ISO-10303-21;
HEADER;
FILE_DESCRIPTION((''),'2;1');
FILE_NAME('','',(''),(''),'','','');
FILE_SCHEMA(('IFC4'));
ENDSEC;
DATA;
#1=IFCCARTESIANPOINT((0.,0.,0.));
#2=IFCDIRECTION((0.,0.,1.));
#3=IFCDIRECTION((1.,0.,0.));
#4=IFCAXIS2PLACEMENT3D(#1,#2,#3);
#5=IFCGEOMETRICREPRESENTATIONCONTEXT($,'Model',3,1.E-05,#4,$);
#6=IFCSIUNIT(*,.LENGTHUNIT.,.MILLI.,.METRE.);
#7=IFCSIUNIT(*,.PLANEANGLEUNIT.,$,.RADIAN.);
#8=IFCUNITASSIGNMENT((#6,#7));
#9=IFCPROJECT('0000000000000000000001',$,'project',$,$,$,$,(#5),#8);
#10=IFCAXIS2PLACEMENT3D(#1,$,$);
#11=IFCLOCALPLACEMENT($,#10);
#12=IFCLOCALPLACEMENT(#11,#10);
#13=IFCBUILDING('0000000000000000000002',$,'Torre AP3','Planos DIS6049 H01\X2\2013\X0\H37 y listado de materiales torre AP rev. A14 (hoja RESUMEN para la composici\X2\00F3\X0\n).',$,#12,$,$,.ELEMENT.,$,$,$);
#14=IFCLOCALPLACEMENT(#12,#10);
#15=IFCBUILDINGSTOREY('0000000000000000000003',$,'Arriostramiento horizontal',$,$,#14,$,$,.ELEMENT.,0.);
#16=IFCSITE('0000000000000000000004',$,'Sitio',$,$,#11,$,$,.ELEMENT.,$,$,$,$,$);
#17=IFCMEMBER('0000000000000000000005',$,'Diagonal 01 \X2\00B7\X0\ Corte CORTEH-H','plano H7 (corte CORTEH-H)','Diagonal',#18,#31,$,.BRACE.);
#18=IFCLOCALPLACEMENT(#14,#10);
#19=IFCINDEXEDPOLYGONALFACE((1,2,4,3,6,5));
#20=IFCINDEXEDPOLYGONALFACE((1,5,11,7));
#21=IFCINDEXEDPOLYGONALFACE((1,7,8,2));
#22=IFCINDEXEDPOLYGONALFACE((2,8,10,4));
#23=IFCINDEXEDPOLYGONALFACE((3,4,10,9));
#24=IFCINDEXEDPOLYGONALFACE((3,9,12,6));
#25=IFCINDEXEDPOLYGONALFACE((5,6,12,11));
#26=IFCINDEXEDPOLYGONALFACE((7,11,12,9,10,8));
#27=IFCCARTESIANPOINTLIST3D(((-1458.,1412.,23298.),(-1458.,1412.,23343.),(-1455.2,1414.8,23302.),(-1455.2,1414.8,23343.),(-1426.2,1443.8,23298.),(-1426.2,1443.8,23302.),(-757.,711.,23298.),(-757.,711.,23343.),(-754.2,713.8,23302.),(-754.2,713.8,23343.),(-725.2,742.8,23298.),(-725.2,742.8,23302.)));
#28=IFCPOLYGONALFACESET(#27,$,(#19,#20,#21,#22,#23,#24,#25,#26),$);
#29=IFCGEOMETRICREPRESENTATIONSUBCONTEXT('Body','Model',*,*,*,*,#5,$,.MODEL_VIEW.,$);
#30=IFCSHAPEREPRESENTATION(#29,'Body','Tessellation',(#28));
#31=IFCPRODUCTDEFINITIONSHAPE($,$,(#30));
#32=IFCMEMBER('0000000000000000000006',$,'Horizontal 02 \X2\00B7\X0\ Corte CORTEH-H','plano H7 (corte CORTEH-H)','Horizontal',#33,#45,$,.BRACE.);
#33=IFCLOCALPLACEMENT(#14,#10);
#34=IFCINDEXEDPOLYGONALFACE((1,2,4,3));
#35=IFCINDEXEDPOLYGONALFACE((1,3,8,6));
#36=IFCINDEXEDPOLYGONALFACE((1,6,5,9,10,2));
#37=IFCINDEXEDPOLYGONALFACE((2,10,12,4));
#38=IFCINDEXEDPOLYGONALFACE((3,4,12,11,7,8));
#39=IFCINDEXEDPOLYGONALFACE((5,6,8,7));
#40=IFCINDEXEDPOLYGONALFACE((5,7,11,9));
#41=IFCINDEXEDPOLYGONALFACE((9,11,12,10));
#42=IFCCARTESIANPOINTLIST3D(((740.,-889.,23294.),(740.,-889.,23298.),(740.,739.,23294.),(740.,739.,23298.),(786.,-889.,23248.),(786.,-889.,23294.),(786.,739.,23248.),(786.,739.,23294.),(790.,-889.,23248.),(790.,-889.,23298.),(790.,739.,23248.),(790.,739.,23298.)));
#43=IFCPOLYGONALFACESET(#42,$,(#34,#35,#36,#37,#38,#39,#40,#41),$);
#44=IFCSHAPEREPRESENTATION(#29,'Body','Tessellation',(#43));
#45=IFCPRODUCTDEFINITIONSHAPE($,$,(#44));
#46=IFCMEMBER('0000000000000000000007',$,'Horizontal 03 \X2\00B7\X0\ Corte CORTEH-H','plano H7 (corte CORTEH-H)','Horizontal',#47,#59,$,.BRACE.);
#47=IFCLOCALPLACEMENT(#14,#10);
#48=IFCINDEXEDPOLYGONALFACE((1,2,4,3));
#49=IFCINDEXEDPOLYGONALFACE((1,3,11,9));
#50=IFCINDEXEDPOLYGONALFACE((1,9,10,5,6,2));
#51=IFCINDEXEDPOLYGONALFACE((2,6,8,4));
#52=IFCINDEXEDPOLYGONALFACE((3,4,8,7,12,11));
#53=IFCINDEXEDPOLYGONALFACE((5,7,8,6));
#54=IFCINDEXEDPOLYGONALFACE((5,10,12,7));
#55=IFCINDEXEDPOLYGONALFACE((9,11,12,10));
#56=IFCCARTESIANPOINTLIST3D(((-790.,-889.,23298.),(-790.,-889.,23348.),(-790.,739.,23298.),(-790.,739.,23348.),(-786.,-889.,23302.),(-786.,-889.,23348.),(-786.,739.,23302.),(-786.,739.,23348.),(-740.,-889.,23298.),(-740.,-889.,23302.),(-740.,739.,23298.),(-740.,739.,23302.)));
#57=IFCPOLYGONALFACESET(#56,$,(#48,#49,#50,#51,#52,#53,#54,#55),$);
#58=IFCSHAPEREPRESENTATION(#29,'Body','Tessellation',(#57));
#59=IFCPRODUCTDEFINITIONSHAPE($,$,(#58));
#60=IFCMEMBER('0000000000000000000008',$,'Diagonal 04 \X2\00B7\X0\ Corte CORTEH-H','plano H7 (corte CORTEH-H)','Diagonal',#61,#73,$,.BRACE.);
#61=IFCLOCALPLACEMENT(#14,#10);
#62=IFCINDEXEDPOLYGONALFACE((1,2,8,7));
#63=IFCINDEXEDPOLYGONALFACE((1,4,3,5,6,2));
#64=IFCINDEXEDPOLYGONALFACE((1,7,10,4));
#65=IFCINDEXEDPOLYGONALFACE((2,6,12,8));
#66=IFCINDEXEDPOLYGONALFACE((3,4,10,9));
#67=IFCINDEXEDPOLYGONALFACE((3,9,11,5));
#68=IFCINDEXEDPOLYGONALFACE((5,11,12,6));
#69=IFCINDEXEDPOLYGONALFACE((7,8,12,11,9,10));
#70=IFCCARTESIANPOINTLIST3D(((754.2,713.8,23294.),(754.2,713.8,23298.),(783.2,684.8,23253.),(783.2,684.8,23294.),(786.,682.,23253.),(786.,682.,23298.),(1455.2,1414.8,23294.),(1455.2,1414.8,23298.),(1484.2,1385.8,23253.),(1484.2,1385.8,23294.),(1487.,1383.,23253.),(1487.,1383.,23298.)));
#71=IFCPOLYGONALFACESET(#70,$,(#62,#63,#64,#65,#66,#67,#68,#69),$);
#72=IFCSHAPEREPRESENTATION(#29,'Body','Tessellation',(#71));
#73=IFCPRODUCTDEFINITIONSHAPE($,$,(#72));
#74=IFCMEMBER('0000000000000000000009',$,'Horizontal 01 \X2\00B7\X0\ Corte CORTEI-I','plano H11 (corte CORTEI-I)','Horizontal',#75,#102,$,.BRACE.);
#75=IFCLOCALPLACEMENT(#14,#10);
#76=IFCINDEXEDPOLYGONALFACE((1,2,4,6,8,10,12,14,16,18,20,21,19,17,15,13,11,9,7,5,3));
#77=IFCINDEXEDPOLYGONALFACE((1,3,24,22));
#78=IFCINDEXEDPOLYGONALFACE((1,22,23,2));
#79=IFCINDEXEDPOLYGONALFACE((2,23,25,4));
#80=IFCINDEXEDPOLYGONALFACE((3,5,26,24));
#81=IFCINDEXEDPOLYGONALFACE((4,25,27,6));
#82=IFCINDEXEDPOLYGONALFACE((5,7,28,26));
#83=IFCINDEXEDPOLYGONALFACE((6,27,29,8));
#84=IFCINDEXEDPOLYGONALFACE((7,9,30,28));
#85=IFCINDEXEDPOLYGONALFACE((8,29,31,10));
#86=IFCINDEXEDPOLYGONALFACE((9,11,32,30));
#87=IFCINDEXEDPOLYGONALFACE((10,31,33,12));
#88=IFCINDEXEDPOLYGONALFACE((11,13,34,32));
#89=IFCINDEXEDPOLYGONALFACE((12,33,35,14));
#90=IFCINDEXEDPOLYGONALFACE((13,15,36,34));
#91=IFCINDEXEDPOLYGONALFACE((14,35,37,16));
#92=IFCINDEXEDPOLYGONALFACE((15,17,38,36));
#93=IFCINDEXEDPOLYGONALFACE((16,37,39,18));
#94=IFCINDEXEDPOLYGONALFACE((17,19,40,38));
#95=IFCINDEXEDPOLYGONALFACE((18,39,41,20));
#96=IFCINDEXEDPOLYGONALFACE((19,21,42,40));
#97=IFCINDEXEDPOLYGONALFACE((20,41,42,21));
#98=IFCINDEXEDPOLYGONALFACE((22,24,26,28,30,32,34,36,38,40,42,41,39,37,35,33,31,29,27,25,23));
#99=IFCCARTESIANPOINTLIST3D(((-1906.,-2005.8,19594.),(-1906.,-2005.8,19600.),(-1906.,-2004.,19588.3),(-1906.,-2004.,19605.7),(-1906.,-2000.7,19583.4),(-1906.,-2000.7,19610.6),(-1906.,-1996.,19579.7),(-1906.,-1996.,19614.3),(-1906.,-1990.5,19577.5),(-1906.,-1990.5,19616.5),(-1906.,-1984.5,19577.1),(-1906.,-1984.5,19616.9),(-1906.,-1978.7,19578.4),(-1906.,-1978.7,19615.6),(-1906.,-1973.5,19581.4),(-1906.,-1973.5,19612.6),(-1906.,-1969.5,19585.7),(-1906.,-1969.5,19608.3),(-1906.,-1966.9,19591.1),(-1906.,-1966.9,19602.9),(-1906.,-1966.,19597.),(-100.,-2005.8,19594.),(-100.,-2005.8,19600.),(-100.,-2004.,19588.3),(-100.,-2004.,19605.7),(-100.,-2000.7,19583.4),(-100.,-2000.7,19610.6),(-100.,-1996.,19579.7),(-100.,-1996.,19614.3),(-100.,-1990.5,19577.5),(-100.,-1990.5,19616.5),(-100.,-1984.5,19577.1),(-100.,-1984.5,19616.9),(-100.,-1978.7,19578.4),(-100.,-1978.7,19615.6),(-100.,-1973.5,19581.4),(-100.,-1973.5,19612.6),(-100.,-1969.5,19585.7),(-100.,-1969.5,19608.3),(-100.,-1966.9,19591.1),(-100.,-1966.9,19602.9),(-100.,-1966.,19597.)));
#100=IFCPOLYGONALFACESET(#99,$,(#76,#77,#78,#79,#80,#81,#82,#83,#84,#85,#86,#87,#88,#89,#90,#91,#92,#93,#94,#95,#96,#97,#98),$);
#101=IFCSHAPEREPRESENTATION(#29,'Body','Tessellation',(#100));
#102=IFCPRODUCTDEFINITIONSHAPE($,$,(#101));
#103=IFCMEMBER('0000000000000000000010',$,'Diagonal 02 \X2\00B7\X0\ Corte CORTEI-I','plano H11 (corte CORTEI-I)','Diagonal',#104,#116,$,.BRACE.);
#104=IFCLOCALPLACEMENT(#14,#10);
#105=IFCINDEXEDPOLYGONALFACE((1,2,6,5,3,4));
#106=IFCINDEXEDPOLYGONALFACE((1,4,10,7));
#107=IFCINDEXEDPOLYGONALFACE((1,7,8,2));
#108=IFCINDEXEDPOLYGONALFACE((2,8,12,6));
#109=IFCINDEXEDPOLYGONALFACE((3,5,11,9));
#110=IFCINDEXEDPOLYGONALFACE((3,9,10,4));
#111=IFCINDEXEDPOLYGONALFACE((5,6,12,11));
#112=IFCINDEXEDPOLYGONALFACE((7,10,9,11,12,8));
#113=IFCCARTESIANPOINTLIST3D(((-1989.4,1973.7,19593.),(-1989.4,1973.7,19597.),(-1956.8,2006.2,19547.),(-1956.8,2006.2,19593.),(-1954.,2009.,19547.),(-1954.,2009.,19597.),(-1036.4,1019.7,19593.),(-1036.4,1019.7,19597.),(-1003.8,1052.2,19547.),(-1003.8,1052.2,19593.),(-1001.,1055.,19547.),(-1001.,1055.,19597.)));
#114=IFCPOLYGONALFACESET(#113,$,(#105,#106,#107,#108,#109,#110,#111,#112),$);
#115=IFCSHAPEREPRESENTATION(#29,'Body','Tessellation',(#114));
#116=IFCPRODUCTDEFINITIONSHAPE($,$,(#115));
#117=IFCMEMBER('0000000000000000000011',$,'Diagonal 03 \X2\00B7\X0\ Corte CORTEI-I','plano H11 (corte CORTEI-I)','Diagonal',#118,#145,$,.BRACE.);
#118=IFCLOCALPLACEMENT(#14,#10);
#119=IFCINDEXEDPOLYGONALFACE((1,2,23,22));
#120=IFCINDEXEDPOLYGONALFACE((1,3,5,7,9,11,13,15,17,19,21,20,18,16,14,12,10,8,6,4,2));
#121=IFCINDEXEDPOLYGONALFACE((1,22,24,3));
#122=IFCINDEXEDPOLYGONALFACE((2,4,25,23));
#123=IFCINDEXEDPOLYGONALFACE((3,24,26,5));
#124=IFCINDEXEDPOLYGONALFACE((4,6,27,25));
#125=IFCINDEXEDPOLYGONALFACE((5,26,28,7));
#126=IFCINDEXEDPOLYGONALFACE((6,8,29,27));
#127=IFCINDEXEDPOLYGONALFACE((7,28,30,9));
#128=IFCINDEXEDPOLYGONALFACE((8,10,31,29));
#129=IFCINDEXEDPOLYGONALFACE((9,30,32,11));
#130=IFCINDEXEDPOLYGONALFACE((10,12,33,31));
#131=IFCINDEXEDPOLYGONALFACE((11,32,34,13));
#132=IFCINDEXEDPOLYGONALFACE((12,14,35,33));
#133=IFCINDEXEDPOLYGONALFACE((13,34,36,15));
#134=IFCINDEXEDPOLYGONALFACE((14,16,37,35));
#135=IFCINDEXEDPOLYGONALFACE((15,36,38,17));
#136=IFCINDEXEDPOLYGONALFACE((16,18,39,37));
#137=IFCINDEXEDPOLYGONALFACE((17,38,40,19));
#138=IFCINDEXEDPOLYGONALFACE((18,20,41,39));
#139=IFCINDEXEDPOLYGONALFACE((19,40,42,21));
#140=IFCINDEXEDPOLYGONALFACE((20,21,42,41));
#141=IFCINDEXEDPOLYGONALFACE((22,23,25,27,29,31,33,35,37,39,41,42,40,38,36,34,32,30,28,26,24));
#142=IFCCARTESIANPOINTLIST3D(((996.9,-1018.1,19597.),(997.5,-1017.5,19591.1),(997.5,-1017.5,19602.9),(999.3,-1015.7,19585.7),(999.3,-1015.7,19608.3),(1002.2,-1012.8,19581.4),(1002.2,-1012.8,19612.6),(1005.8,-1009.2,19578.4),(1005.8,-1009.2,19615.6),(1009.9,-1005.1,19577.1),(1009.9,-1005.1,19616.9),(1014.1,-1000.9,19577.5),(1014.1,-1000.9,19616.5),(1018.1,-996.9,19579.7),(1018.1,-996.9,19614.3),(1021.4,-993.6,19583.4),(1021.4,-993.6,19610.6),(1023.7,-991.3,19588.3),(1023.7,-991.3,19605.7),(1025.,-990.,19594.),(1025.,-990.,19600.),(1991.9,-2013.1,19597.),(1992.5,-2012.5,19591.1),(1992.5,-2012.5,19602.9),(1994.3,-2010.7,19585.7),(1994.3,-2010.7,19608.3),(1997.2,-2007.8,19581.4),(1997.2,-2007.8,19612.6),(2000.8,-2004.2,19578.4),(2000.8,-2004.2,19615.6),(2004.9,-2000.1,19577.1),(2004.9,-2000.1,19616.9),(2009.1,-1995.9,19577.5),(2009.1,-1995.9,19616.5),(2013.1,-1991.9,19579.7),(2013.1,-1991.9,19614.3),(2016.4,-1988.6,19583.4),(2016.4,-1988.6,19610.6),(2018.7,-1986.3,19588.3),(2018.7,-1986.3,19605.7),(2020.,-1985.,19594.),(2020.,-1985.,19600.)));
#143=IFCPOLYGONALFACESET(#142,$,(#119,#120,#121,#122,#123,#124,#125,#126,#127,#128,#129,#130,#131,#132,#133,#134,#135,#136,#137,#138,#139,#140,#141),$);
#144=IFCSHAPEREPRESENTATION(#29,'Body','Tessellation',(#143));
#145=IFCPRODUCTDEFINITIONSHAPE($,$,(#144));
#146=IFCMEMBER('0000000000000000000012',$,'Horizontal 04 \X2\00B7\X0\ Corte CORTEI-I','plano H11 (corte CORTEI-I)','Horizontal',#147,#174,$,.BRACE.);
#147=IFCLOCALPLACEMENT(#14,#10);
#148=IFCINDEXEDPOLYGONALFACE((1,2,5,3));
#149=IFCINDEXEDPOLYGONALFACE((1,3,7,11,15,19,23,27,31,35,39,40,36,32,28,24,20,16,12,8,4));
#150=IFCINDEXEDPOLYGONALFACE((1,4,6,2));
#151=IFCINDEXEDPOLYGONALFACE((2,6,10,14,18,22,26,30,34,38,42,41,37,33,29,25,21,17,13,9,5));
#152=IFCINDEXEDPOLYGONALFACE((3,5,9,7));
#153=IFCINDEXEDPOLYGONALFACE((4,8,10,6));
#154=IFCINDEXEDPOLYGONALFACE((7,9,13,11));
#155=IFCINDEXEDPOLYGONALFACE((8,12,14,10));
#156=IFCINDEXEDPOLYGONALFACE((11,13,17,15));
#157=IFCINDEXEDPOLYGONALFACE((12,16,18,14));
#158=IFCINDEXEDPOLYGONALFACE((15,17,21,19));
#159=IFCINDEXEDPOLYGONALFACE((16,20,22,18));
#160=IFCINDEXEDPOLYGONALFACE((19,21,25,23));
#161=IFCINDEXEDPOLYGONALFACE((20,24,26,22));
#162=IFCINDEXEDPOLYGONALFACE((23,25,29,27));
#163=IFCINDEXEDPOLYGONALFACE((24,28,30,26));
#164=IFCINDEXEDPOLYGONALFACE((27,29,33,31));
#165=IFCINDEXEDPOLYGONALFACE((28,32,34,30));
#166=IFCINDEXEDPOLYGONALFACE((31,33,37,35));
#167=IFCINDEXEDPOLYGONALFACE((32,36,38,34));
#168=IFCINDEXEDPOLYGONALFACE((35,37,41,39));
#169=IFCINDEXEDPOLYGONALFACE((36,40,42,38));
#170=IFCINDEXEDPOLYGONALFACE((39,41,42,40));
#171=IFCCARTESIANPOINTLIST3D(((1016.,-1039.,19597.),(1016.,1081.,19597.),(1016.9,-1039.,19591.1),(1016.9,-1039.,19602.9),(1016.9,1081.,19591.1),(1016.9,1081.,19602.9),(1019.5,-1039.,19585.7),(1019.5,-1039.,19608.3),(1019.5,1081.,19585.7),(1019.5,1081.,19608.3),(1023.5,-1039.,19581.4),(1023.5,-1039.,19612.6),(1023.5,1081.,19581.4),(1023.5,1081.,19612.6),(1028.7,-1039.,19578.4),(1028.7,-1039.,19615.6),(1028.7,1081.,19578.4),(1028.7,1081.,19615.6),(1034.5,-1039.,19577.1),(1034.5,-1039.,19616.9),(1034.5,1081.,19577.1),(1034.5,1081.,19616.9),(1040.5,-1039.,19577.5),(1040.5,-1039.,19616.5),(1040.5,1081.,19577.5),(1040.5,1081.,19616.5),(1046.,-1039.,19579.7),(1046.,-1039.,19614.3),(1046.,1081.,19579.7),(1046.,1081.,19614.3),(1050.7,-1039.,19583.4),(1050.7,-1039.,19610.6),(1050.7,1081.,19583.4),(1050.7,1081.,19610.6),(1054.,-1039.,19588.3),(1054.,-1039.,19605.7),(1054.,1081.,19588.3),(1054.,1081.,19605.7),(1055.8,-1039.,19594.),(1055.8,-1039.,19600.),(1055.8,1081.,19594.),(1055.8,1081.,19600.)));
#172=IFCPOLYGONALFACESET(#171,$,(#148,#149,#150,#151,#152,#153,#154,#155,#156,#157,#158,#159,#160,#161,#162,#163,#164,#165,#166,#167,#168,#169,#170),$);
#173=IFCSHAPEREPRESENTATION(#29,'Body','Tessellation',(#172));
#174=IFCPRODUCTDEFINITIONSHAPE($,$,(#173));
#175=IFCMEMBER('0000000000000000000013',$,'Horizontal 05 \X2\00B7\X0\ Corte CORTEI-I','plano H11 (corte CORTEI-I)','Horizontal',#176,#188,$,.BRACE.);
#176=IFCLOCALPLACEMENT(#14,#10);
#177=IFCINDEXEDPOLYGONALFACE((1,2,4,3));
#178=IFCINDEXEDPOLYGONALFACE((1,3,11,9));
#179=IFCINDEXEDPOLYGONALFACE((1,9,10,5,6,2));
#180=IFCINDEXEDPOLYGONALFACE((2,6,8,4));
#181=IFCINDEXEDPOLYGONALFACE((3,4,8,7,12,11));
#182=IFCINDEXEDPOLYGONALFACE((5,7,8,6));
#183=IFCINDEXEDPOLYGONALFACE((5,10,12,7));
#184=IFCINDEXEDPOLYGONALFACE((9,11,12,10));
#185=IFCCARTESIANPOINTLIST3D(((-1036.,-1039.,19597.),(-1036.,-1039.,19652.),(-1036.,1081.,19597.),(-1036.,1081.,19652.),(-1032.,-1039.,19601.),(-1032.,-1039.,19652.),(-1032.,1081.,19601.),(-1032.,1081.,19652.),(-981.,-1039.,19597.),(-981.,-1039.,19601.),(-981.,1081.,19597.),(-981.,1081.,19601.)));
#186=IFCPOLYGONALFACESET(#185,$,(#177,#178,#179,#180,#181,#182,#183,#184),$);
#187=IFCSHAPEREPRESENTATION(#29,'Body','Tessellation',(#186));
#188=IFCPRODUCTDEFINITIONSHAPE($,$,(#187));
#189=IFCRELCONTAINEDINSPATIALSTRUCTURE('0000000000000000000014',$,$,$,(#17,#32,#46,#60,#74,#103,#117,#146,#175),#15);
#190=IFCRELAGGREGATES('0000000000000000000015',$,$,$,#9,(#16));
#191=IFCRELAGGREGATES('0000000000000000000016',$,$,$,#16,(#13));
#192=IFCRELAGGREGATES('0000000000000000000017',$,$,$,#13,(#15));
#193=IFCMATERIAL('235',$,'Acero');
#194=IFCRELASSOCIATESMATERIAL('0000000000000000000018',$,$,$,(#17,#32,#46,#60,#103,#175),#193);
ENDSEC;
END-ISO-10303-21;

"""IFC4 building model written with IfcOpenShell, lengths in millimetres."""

from ifc_helpers import new_model, si_unit, frame, frame_2d, origin, origin_with_axes, place, context, subcontext, project, spatial, circle, l_section, extrude, material, element, save


model = new_model("IFC4")

# Units and contexts
model_context = context("Model", 3, precision=1e-05, world=origin_with_axes())
body_context = subcontext(model_context, "Body", "Model", "MODEL_VIEW")
ifc_project = project(units=[si_unit("LENGTHUNIT", "METRE", prefix="MILLI"), si_unit("PLANEANGLEUNIT", "RADIAN")], contexts=[model_context])

# Site, building, storey
site_placement = place(None, origin())
site = spatial("IfcSite", under=ifc_project, at=site_placement, Name="Sitio", CompositionType="ELEMENT")
building_placement = place(site_placement, origin())
building = spatial("IfcBuilding", under=site, at=building_placement, Name="Torre AP3", Description="Planos DIS6049 H01–H37 y listado de materiales torre AP rev. A14 (hoja RESUMEN para la composición).", CompositionType="ELEMENT")
storey_placement = place(building_placement, origin())
storey = spatial("IfcBuildingStorey", under=building, at=storey_placement, Name="Arriostramiento horizontal", CompositionType="ELEMENT", Elevation=0.0)

# Members
ifc_material = material(Name="235", Category="Acero")
member_1_placement = place(storey_placement, frame((-1458.0, 1412.0, 23298.0), z_axis=(0.707107, -0.707107, 0.0), x_axis=(0.707107, 0.707107, 0.0)))
element("IfcMember", 1, at=member_1_placement, inside=storey, material=ifc_material, Name="Diagonal 01 · Corte CORTEH-H", Description="plano H7 (corte CORTEH-H)", ObjectType="Diagonal", PredefinedType="BRACE", context=body_context, shape_type="SweptSolid", body=[
    extrude(l_section(Depth=45.0, Width=45.0, Thickness=4.0, at=frame_2d((22.5, 22.5))), None, (0.0, 0.0, 1.0), 991.4),
])
for number, where, z_axis, x_axis, name in (
    (2, (790.0, 739.0, 23298.0), (0.0, -1.0, 0.0), (-1.0, 0.0, 0.0), "Horizontal 02 · Corte CORTEH-H"),
    (3, (-790.0, 739.0, 23298.0), (0.0, -1.0, 0.0), (1.0, 0.0, 0.0), "Horizontal 03 · Corte CORTEH-H"),
):
    element("IfcMember", number, at=place(storey_placement, frame(where, z_axis=z_axis, x_axis=x_axis)), inside=storey, material=ifc_material, Name=name, Description="plano H7 (corte CORTEH-H)", ObjectType="Horizontal", PredefinedType="BRACE", context=body_context, shape_type="SweptSolid", body=[
        extrude(l_section(Depth=50.0, Width=50.0, Thickness=4.0, at=frame_2d((25.0, 25.0))), None, (0.0, 0.0, 1.0), 1628.0),
    ])
member_2_placement = place(storey_placement, frame((1487.0, 1383.0, 23298.0), z_axis=(-0.707107, -0.707107, 0.0), x_axis=(-0.707107, 0.707107, 0.0)))
element("IfcMember", 4, at=member_2_placement, inside=storey, material=ifc_material, Name="Diagonal 04 · Corte CORTEH-H", Description="plano H7 (corte CORTEH-H)", ObjectType="Diagonal", PredefinedType="BRACE", context=body_context, shape_type="SweptSolid", body=[
    extrude(l_section(Depth=45.0, Width=45.0, Thickness=4.0, at=frame_2d((22.5, 22.5))), None, (0.0, 0.0, 1.0), 991.4),
])
member_3_placement = place(storey_placement, frame((-1906.0, -1986.0, 19597.0), z_axis=(1.0, 0.0, 0.0), x_axis=(0.0, 1.0, 0.0)))
element("IfcMember", 5, at=member_3_placement, inside=storey, Name="Horizontal 01 · Corte CORTEI-I", Description="plano H11 (corte CORTEI-I)", ObjectType="Horizontal", PredefinedType="BRACE", context=body_context, shape_type="SweptSolid", body=[
    extrude(circle(Radius=20.0), None, (0.0, 0.0, 1.0), 1806.0),
])
member_4_placement = place(storey_placement, frame((-1954.0, 2009.0, 19597.0), z_axis=(0.706736, -0.707477, 0.0), x_axis=(-0.707477, -0.706736, 0.0)))
element("IfcMember", 6, at=member_4_placement, inside=storey, material=ifc_material, Name="Diagonal 02 · Corte CORTEI-I", Description="plano H11 (corte CORTEI-I)", ObjectType="Diagonal", PredefinedType="BRACE", context=body_context, shape_type="SweptSolid", body=[
    extrude(l_section(Depth=50.0, Width=50.0, Thickness=4.0, at=frame_2d((25.0, 25.0))), None, (0.0, 0.0, 1.0), 1348.5),
])
member_5_placement = place(storey_placement, frame((1011.0, -1004.0, 19597.0), z_axis=(0.707107, -0.707107, 0.0), x_axis=(-0.707107, -0.707107, 0.0)))
element("IfcMember", 7, at=member_5_placement, inside=storey, Name="Diagonal 03 · Corte CORTEI-I", Description="plano H11 (corte CORTEI-I)", ObjectType="Diagonal", PredefinedType="BRACE", context=body_context, shape_type="SweptSolid", body=[
    extrude(circle(Radius=20.0), None, (0.0, 0.0, 1.0), 1407.1),
])
member_6_placement = place(storey_placement, frame((1036.0, 1081.0, 19597.0), z_axis=(0.0, -1.0, 0.0), x_axis=(-1.0, 0.0, 0.0)))
element("IfcMember", 8, at=member_6_placement, inside=storey, Name="Horizontal 04 · Corte CORTEI-I", Description="plano H11 (corte CORTEI-I)", ObjectType="Horizontal", PredefinedType="BRACE", context=body_context, shape_type="SweptSolid", body=[
    extrude(circle(Radius=20.0), None, (0.0, 0.0, 1.0), 2120.0),
])
member_7_placement = place(storey_placement, frame((-1036.0, 1081.0, 19597.0), z_axis=(0.0, -1.0, 0.0), x_axis=(1.0, 0.0, 0.0)))
element("IfcMember", 9, at=member_7_placement, inside=storey, material=ifc_material, Name="Horizontal 05 · Corte CORTEI-I", Description="plano H11 (corte CORTEI-I)", ObjectType="Horizontal", PredefinedType="BRACE", context=body_context, shape_type="SweptSolid", body=[
    extrude(l_section(Depth=55.0, Width=55.0, Thickness=4.0, at=frame_2d((27.5, 27.5))), None, (0.0, 0.0, 1.0), 2120.0),
])

save(model, "model.ifc")
